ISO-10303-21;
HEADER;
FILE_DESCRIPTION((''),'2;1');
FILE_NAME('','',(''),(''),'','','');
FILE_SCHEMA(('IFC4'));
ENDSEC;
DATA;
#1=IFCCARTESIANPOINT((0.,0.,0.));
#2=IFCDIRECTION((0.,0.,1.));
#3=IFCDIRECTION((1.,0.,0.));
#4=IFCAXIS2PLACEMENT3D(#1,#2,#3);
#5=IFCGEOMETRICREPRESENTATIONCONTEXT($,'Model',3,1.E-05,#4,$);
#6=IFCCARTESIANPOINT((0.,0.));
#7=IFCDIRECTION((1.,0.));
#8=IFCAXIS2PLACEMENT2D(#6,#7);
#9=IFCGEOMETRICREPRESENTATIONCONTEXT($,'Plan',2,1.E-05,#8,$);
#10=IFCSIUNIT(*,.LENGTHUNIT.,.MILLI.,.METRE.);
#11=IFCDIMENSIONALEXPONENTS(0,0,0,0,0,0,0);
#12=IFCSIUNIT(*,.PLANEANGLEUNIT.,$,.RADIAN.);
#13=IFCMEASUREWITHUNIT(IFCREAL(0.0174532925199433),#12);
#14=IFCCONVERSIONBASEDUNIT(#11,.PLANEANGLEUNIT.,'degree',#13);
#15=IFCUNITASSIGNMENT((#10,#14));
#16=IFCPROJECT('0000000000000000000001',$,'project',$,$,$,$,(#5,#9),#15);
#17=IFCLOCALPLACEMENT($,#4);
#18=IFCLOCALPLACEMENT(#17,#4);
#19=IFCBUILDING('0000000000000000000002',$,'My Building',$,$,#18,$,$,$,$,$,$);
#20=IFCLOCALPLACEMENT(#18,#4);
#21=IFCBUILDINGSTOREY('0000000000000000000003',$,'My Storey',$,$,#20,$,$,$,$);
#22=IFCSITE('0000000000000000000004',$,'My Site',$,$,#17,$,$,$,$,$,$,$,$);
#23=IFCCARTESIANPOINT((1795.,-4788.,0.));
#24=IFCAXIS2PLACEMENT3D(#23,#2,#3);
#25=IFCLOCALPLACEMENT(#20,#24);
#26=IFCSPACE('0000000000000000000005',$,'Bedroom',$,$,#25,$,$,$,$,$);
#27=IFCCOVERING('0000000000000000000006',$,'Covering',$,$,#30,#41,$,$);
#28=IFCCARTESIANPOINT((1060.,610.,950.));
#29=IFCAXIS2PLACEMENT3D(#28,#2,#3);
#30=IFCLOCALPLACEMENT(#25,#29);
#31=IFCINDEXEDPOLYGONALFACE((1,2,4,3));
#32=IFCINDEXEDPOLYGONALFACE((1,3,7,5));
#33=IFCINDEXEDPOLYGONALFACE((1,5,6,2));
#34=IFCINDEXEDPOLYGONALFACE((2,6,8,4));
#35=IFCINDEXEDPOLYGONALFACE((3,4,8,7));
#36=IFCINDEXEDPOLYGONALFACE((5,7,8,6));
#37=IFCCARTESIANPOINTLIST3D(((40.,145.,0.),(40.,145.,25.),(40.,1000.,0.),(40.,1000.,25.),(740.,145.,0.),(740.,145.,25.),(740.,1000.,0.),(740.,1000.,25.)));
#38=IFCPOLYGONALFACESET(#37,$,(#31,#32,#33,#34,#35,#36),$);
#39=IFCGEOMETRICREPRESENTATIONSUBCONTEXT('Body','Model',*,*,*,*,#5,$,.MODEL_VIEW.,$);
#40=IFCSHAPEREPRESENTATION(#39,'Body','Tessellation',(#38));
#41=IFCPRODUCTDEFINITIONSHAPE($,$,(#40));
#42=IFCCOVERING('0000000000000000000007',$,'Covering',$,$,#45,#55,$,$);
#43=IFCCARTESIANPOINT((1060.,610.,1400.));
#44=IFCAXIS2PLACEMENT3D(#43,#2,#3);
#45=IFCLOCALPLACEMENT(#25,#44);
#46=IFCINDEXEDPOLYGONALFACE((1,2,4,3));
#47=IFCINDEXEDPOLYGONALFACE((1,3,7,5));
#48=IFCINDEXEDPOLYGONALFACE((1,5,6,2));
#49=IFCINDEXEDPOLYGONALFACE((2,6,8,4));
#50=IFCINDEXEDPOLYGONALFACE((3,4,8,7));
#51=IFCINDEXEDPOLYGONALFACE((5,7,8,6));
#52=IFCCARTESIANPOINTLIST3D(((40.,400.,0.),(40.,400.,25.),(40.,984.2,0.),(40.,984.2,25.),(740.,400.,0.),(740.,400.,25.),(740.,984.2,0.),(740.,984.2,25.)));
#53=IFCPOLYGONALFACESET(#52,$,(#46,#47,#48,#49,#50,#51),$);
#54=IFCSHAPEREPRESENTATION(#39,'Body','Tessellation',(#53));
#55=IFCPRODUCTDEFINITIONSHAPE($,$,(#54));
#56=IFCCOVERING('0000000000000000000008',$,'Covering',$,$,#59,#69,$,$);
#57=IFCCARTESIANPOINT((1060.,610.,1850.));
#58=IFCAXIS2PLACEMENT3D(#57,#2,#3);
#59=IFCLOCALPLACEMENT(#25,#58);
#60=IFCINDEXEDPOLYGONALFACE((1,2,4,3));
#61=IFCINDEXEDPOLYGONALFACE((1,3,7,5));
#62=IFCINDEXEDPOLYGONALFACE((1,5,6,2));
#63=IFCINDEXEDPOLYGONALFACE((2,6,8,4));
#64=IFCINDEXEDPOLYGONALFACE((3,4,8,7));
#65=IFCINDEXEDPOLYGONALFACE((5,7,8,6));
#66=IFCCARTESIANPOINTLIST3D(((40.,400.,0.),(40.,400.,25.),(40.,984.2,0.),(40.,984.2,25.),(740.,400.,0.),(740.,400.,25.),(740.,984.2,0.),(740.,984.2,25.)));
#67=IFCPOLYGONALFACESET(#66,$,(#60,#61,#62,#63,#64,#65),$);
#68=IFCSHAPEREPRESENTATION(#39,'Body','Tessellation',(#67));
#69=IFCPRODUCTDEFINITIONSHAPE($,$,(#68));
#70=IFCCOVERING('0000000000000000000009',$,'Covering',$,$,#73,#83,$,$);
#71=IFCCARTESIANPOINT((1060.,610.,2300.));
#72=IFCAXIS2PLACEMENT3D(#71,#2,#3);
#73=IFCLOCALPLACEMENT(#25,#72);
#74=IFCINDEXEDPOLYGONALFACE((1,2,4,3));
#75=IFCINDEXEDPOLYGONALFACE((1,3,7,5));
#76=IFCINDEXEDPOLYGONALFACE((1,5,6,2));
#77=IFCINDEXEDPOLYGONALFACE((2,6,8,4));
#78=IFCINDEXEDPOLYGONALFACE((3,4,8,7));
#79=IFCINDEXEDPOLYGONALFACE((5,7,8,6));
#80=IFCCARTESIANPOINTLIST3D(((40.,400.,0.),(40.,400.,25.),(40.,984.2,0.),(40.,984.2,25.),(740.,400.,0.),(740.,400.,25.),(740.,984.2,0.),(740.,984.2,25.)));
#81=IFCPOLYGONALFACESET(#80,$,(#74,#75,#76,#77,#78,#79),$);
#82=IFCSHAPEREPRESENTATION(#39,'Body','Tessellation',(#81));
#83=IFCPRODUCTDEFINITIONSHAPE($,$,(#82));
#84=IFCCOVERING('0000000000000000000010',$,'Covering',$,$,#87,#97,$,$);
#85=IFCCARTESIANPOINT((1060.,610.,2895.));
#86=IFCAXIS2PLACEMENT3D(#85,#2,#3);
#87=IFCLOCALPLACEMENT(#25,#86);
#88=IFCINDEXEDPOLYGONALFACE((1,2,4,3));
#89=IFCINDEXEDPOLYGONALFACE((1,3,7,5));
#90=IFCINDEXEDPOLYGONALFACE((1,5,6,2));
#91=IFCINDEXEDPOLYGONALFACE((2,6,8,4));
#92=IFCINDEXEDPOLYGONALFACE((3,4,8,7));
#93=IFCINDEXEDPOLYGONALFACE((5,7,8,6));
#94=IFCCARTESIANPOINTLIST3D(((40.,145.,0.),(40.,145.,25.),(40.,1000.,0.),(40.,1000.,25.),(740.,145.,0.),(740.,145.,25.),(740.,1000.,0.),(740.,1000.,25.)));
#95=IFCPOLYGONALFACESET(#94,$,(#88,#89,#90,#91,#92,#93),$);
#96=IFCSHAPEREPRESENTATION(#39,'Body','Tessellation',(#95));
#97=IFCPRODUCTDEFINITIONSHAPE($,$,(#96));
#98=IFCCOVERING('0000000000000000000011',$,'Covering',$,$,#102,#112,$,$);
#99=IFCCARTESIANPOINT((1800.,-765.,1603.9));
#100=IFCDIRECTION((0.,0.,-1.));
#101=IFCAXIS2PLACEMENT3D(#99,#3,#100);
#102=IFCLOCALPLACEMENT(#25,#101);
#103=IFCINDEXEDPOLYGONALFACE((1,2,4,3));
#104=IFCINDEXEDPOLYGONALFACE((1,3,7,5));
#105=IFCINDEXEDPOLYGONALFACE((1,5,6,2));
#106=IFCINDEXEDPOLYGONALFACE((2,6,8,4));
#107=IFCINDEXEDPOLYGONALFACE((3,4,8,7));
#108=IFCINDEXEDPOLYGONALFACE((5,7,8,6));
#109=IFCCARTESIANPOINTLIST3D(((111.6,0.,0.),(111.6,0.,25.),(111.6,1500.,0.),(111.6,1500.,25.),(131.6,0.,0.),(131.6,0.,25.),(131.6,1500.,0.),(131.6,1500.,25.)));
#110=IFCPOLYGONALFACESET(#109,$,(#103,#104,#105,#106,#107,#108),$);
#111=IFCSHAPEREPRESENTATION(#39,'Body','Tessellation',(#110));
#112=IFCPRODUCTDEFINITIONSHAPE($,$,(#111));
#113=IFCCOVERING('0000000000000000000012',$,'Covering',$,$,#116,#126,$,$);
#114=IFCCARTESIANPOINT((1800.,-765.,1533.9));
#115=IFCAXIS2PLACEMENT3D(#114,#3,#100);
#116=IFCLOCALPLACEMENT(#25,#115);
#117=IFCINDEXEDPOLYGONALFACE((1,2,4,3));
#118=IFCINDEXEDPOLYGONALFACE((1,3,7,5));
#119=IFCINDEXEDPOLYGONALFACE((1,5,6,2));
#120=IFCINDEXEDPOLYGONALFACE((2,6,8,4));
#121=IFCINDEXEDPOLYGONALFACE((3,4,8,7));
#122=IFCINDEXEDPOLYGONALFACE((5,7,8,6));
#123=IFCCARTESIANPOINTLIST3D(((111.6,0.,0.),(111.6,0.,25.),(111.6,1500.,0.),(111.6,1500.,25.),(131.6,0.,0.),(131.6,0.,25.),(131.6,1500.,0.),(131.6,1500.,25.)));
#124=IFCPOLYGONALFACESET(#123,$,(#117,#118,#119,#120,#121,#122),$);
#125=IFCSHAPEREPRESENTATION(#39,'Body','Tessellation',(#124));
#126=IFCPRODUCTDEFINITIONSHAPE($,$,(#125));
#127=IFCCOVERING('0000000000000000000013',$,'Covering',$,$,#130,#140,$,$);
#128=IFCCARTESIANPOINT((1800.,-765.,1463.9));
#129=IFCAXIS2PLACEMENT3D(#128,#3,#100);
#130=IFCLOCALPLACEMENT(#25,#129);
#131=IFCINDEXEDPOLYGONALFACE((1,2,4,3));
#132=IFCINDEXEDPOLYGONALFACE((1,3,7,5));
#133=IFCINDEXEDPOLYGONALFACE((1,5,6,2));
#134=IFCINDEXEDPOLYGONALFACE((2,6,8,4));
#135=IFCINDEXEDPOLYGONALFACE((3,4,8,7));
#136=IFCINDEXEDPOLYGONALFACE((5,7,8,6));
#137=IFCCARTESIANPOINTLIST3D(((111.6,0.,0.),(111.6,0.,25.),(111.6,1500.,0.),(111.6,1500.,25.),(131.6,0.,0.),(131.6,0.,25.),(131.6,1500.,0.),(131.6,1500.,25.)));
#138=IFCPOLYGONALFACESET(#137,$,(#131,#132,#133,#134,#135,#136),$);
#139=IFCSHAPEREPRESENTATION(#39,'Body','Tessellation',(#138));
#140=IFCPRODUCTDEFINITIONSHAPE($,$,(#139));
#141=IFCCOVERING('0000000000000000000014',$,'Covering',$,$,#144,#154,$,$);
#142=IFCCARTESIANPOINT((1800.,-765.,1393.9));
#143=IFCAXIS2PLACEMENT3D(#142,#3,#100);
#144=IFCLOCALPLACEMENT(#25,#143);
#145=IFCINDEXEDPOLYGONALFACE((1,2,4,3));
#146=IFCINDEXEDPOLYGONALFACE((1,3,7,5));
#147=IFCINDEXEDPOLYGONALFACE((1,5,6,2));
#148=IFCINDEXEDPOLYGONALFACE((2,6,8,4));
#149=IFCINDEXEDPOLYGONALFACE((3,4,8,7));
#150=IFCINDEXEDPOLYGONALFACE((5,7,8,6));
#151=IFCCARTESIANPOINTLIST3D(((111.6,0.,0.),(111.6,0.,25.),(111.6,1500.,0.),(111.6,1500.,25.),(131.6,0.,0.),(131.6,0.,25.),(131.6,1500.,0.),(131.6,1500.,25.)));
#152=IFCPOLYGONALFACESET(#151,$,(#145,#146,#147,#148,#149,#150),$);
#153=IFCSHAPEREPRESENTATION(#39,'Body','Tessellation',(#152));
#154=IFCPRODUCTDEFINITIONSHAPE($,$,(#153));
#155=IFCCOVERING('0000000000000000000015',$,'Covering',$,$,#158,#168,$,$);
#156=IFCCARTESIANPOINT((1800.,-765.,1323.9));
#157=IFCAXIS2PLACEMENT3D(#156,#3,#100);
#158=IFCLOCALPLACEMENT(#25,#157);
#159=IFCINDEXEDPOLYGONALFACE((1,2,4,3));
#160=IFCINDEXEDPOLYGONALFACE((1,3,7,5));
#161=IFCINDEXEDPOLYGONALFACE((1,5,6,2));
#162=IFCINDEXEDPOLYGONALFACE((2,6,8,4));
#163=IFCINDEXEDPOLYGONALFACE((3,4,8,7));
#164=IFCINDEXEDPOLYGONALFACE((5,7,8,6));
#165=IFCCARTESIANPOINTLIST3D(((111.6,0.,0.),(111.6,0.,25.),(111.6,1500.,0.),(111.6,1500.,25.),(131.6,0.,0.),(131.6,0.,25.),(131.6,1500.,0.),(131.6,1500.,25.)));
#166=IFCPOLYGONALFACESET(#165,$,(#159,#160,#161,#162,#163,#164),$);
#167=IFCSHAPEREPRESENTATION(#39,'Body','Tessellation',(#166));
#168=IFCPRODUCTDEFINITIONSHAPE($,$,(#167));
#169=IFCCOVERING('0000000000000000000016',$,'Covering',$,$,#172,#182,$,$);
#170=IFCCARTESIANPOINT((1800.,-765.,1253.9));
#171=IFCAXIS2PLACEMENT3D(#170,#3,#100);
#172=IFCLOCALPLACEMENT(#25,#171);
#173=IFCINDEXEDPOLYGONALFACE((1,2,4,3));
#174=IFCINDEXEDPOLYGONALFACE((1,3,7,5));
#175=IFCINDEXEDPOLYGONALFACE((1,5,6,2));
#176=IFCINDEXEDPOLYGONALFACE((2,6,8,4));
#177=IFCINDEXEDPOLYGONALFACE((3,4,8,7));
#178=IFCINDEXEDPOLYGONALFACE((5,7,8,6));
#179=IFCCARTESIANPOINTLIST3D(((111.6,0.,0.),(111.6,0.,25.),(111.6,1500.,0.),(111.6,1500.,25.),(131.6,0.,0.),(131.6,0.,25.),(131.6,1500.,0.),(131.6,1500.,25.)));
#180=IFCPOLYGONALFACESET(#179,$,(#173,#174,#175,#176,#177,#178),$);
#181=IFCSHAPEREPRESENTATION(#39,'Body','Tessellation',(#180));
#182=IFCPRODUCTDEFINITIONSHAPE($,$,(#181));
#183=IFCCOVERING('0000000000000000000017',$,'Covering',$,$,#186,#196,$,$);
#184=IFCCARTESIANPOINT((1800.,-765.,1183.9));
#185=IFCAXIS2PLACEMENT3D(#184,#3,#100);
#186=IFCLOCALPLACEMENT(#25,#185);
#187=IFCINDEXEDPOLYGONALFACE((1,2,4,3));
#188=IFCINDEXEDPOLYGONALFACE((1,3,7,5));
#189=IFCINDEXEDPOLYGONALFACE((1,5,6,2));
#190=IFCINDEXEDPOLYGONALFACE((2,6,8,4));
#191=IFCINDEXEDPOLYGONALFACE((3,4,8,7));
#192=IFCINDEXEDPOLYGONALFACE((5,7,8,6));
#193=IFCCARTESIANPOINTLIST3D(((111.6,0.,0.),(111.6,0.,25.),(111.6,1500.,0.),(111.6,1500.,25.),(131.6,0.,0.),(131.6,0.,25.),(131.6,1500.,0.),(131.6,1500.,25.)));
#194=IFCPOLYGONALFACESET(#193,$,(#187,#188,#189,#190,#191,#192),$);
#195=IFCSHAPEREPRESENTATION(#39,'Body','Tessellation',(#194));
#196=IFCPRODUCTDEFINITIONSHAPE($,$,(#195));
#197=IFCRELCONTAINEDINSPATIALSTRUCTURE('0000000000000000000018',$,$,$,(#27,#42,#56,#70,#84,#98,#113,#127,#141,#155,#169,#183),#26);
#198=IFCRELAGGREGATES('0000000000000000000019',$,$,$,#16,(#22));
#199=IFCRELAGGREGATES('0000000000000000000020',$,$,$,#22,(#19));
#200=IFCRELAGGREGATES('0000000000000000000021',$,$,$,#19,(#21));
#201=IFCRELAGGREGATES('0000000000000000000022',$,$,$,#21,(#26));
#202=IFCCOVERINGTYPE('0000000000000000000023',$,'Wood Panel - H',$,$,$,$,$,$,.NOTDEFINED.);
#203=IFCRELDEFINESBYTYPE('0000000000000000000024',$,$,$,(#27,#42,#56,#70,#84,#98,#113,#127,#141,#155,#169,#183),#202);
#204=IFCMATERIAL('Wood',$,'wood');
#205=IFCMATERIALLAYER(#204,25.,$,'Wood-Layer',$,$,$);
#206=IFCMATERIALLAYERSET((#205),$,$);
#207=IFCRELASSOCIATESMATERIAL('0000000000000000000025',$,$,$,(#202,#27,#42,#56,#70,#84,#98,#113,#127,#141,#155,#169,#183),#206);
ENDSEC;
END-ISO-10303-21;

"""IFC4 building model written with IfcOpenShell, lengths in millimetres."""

from ifc_helpers import new_model, entity, si_unit, converted_unit, frame, origin_with_axes, origin_2d_with_axis, place, context, subcontext, project, spatial, line, indexed_curve, outline, extrude, material, layer, layer_set, layer_usage, type_object, element, save


model = new_model("IFC4")

# Units and contexts
model_context = context("Model", 3, precision=1e-05, world=origin_with_axes())
plan_context = context("Plan", 2, precision=1e-05, world=origin_2d_with_axis())
body_context_1 = subcontext(model_context, "Body", "Model", "MODEL_VIEW")
ifc_project = project(units=[si_unit("LENGTHUNIT", "METRE", prefix="MILLI"), converted_unit("PLANEANGLEUNIT", "degree", entity("IfcReal", 0.0174532925199433), si_unit("PLANEANGLEUNIT", "RADIAN"), dimensions=[0, 0, 0, 0, 0, 0, 0])], contexts=[model_context, plan_context])

# Site, building, storey
site_placement = place(None, origin_with_axes())
site = spatial("IfcSite", under=ifc_project, at=site_placement, Name="My Site")
building_placement = place(site_placement, origin_with_axes())
building = spatial("IfcBuilding", under=site, at=building_placement, Name="My Building")
storey_placement = place(building_placement, origin_with_axes())
storey = spatial("IfcBuildingStorey", under=building, at=storey_placement, Name="My Storey")

# Shared definitions
space_1_placement = place(storey_placement, frame((1795.0, -4788.0, 0.0), z_axis=(0.0, 0.0, 1.0), x_axis=(1.0, 0.0, 0.0)))
space_1 = spatial("IfcSpace", under=storey, at=space_1_placement, Name="Bedroom")

# Coverings
ifc_material_1 = material(Name="Wood", Category="wood")
ifc_layer_1 = layer(ifc_material_1, 25.0, Name="Wood-Layer")
ifc_layer_set_1 = layer_set([ifc_layer_1])
covering_type_1 = type_object("IfcCoveringType", Name="Wood Panel - H", PredefinedType="NOTDEFINED", material=ifc_layer_set_1)
ifc_layer_usage_1 = layer_usage(ifc_layer_set_1, "AXIS3", "POSITIVE", 0.0)
covering_1_placement = place(space_1_placement, frame((1060.0, 610.0, 950.0), z_axis=(0.0, 0.0, 1.0), x_axis=(1.0, 0.0, 0.0)))
element("IfcCovering", 1, at=covering_1_placement, inside=space_1, type_object=covering_type_1, material=ifc_layer_usage_1, Name="Covering", context=body_context_1, shape_type="SweptSolid", body=[
    extrude(outline(indexed_curve([(40.0, 145.0), (740.0, 145.0), (740.0, 1000.0), (40.0, 1000.0)], segments=[line(4, 1), line(1, 2), line(2, 3), line(3, 4)], self_intersect=False)), None, (0.0, 0.0, 1.0), 25.0),
])
ifc_layer_usage_2 = layer_usage(ifc_layer_set_1, "AXIS3", "POSITIVE", 0.0)
covering_2_placement = place(space_1_placement, frame((1060.0, 610.0, 1400.0), z_axis=(0.0, 0.0, 1.0), x_axis=(1.0, 0.0, 0.0)))
element("IfcCovering", 2, at=covering_2_placement, inside=space_1, type_object=covering_type_1, material=ifc_layer_usage_2, Name="Covering", context=body_context_1, shape_type="SweptSolid", body=[
    extrude(outline(indexed_curve([(740.0, 400.0), (40.0, 400.0), (40.0, 984.2), (740.0, 984.2)], segments=[line(3, 2), line(2, 1), line(1, 4), line(4, 3)], self_intersect=False)), None, (0.0, 0.0, 1.0), 25.0),
])
ifc_layer_usage_3 = layer_usage(ifc_layer_set_1, "AXIS3", "POSITIVE", 0.0)
covering_3_placement = place(space_1_placement, frame((1060.0, 610.0, 1850.0), z_axis=(0.0, 0.0, 1.0), x_axis=(1.0, 0.0, 0.0)))
element("IfcCovering", 3, at=covering_3_placement, inside=space_1, type_object=covering_type_1, material=ifc_layer_usage_3, Name="Covering", context=body_context_1, shape_type="SweptSolid", body=[
    extrude(outline(indexed_curve([(740.0, 400.0), (40.0, 400.0), (40.0, 984.2), (740.0, 984.2)], segments=[line(3, 2), line(2, 1), line(1, 4), line(4, 3)], self_intersect=False)), None, (0.0, 0.0, 1.0), 25.0),
])
ifc_layer_usage_4 = layer_usage(ifc_layer_set_1, "AXIS3", "POSITIVE", 0.0)
covering_4_placement = place(space_1_placement, frame((1060.0, 610.0, 2300.0), z_axis=(0.0, 0.0, 1.0), x_axis=(1.0, 0.0, 0.0)))
element("IfcCovering", 4, at=covering_4_placement, inside=space_1, type_object=covering_type_1, material=ifc_layer_usage_4, Name="Covering", context=body_context_1, shape_type="SweptSolid", body=[
    extrude(outline(indexed_curve([(740.0, 400.0), (40.0, 400.0), (40.0, 984.2), (740.0, 984.2)], segments=[line(3, 2), line(2, 1), line(1, 4), line(4, 3)], self_intersect=False)), None, (0.0, 0.0, 1.0), 25.0),
])
ifc_layer_usage_5 = layer_usage(ifc_layer_set_1, "AXIS3", "POSITIVE", 0.0)
covering_5_placement = place(space_1_placement, frame((1060.0, 610.0, 2895.0), z_axis=(0.0, 0.0, 1.0), x_axis=(1.0, 0.0, 0.0)))
element("IfcCovering", 5, at=covering_5_placement, inside=space_1, type_object=covering_type_1, material=ifc_layer_usage_5, Name="Covering", context=body_context_1, shape_type="SweptSolid", body=[
    extrude(outline(indexed_curve([(40.0, 145.0), (740.0, 145.0), (740.0, 1000.0), (40.0, 1000.0)], segments=[line(4, 1), line(1, 2), line(2, 3), line(3, 4)], self_intersect=False)), None, (0.0, 0.0, 1.0), 25.0),
])
ifc_layer_usage_6 = layer_usage(ifc_layer_set_1, "AXIS3", "POSITIVE", 0.0)
covering_6_placement = place(space_1_placement, frame((1800.0, -765.0, 1603.9), z_axis=(1.0, 0.0, 0.0), x_axis=(0.0, 0.0, -1.0)))
element("IfcCovering", 6, at=covering_6_placement, inside=space_1, type_object=covering_type_1, material=ifc_layer_usage_6, Name="Covering", context=body_context_1, shape_type="SweptSolid", body=[
    extrude(outline(indexed_curve([(131.6, 1500.0), (111.6, 1500.0), (111.6, 0.0), (131.6, 0.0)], segments=[line(3, 2), line(2, 1), line(1, 4), line(4, 3)], self_intersect=False)), None, (0.0, 0.0, 1.0), 25.0),
])
ifc_layer_usage_7 = layer_usage(ifc_layer_set_1, "AXIS3", "POSITIVE", 0.0)
covering_7_placement = place(space_1_placement, frame((1800.0, -765.0, 1533.9), z_axis=(1.0, 0.0, 0.0), x_axis=(0.0, 0.0, -1.0)))
element("IfcCovering", 7, at=covering_7_placement, inside=space_1, type_object=covering_type_1, material=ifc_layer_usage_7, Name="Covering", context=body_context_1, shape_type="SweptSolid", body=[
    extrude(outline(indexed_curve([(131.6, 1500.0), (111.6, 1500.0), (111.6, 0.0), (131.6, 0.0)], segments=[line(3, 2), line(2, 1), line(1, 4), line(4, 3)], self_intersect=False)), None, (0.0, 0.0, 1.0), 25.0),
])
ifc_layer_usage_8 = layer_usage(ifc_layer_set_1, "AXIS3", "POSITIVE", 0.0)
covering_8_placement = place(space_1_placement, frame((1800.0, -765.0, 1463.9), z_axis=(1.0, 0.0, 0.0), x_axis=(0.0, 0.0, -1.0)))
element("IfcCovering", 8, at=covering_8_placement, inside=space_1, type_object=covering_type_1, material=ifc_layer_usage_8, Name="Covering", context=body_context_1, shape_type="SweptSolid", body=[
    extrude(outline(indexed_curve([(131.6, 1500.0), (111.6, 1500.0), (111.6, 0.0), (131.6, 0.0)], segments=[line(3, 2), line(2, 1), line(1, 4), line(4, 3)], self_intersect=False)), None, (0.0, 0.0, 1.0), 25.0),
])
ifc_layer_usage_9 = layer_usage(ifc_layer_set_1, "AXIS3", "POSITIVE", 0.0)
covering_9_placement = place(space_1_placement, frame((1800.0, -765.0, 1393.9), z_axis=(1.0, 0.0, 0.0), x_axis=(0.0, 0.0, -1.0)))
element("IfcCovering", 9, at=covering_9_placement, inside=space_1, type_object=covering_type_1, material=ifc_layer_usage_9, Name="Covering", context=body_context_1, shape_type="SweptSolid", body=[
    extrude(outline(indexed_curve([(131.6, 1500.0), (111.6, 1500.0), (111.6, 0.0), (131.6, 0.0)], segments=[line(3, 2), line(2, 1), line(1, 4), line(4, 3)], self_intersect=False)), None, (0.0, 0.0, 1.0), 25.0),
])
ifc_layer_usage_10 = layer_usage(ifc_layer_set_1, "AXIS3", "POSITIVE", 0.0)
covering_10_placement = place(space_1_placement, frame((1800.0, -765.0, 1323.9), z_axis=(1.0, 0.0, 0.0), x_axis=(0.0, 0.0, -1.0)))
element("IfcCovering", 10, at=covering_10_placement, inside=space_1, type_object=covering_type_1, material=ifc_layer_usage_10, Name="Covering", context=body_context_1, shape_type="SweptSolid", body=[
    extrude(outline(indexed_curve([(131.6, 1500.0), (111.6, 1500.0), (111.6, 0.0), (131.6, 0.0)], segments=[line(3, 2), line(2, 1), line(1, 4), line(4, 3)], self_intersect=False)), None, (0.0, 0.0, 1.0), 25.0),
])
ifc_layer_usage_11 = layer_usage(ifc_layer_set_1, "AXIS3", "POSITIVE", 0.0)
covering_11_placement = place(space_1_placement, frame((1800.0, -765.0, 1253.9), z_axis=(1.0, 0.0, 0.0), x_axis=(0.0, 0.0, -1.0)))
element("IfcCovering", 11, at=covering_11_placement, inside=space_1, type_object=covering_type_1, material=ifc_layer_usage_11, Name="Covering", context=body_context_1, shape_type="SweptSolid", body=[
    extrude(outline(indexed_curve([(131.6, 1500.0), (111.6, 1500.0), (111.6, 0.0), (131.6, 0.0)], segments=[line(3, 2), line(2, 1), line(1, 4), line(4, 3)], self_intersect=False)), None, (0.0, 0.0, 1.0), 25.0),
])
ifc_layer_usage_12 = layer_usage(ifc_layer_set_1, "AXIS3", "POSITIVE", 0.0)
covering_12_placement = place(space_1_placement, frame((1800.0, -765.0, 1183.9), z_axis=(1.0, 0.0, 0.0), x_axis=(0.0, 0.0, -1.0)))
element("IfcCovering", 12, at=covering_12_placement, inside=space_1, type_object=covering_type_1, material=ifc_layer_usage_12, Name="Covering", context=body_context_1, shape_type="SweptSolid", body=[
    extrude(outline(indexed_curve([(131.6, 1500.0), (111.6, 1500.0), (111.6, 0.0), (131.6, 0.0)], segments=[line(3, 2), line(2, 1), line(1, 4), line(4, 3)], self_intersect=False)), None, (0.0, 0.0, 1.0), 25.0),
])

save(model, "model.ifc")
